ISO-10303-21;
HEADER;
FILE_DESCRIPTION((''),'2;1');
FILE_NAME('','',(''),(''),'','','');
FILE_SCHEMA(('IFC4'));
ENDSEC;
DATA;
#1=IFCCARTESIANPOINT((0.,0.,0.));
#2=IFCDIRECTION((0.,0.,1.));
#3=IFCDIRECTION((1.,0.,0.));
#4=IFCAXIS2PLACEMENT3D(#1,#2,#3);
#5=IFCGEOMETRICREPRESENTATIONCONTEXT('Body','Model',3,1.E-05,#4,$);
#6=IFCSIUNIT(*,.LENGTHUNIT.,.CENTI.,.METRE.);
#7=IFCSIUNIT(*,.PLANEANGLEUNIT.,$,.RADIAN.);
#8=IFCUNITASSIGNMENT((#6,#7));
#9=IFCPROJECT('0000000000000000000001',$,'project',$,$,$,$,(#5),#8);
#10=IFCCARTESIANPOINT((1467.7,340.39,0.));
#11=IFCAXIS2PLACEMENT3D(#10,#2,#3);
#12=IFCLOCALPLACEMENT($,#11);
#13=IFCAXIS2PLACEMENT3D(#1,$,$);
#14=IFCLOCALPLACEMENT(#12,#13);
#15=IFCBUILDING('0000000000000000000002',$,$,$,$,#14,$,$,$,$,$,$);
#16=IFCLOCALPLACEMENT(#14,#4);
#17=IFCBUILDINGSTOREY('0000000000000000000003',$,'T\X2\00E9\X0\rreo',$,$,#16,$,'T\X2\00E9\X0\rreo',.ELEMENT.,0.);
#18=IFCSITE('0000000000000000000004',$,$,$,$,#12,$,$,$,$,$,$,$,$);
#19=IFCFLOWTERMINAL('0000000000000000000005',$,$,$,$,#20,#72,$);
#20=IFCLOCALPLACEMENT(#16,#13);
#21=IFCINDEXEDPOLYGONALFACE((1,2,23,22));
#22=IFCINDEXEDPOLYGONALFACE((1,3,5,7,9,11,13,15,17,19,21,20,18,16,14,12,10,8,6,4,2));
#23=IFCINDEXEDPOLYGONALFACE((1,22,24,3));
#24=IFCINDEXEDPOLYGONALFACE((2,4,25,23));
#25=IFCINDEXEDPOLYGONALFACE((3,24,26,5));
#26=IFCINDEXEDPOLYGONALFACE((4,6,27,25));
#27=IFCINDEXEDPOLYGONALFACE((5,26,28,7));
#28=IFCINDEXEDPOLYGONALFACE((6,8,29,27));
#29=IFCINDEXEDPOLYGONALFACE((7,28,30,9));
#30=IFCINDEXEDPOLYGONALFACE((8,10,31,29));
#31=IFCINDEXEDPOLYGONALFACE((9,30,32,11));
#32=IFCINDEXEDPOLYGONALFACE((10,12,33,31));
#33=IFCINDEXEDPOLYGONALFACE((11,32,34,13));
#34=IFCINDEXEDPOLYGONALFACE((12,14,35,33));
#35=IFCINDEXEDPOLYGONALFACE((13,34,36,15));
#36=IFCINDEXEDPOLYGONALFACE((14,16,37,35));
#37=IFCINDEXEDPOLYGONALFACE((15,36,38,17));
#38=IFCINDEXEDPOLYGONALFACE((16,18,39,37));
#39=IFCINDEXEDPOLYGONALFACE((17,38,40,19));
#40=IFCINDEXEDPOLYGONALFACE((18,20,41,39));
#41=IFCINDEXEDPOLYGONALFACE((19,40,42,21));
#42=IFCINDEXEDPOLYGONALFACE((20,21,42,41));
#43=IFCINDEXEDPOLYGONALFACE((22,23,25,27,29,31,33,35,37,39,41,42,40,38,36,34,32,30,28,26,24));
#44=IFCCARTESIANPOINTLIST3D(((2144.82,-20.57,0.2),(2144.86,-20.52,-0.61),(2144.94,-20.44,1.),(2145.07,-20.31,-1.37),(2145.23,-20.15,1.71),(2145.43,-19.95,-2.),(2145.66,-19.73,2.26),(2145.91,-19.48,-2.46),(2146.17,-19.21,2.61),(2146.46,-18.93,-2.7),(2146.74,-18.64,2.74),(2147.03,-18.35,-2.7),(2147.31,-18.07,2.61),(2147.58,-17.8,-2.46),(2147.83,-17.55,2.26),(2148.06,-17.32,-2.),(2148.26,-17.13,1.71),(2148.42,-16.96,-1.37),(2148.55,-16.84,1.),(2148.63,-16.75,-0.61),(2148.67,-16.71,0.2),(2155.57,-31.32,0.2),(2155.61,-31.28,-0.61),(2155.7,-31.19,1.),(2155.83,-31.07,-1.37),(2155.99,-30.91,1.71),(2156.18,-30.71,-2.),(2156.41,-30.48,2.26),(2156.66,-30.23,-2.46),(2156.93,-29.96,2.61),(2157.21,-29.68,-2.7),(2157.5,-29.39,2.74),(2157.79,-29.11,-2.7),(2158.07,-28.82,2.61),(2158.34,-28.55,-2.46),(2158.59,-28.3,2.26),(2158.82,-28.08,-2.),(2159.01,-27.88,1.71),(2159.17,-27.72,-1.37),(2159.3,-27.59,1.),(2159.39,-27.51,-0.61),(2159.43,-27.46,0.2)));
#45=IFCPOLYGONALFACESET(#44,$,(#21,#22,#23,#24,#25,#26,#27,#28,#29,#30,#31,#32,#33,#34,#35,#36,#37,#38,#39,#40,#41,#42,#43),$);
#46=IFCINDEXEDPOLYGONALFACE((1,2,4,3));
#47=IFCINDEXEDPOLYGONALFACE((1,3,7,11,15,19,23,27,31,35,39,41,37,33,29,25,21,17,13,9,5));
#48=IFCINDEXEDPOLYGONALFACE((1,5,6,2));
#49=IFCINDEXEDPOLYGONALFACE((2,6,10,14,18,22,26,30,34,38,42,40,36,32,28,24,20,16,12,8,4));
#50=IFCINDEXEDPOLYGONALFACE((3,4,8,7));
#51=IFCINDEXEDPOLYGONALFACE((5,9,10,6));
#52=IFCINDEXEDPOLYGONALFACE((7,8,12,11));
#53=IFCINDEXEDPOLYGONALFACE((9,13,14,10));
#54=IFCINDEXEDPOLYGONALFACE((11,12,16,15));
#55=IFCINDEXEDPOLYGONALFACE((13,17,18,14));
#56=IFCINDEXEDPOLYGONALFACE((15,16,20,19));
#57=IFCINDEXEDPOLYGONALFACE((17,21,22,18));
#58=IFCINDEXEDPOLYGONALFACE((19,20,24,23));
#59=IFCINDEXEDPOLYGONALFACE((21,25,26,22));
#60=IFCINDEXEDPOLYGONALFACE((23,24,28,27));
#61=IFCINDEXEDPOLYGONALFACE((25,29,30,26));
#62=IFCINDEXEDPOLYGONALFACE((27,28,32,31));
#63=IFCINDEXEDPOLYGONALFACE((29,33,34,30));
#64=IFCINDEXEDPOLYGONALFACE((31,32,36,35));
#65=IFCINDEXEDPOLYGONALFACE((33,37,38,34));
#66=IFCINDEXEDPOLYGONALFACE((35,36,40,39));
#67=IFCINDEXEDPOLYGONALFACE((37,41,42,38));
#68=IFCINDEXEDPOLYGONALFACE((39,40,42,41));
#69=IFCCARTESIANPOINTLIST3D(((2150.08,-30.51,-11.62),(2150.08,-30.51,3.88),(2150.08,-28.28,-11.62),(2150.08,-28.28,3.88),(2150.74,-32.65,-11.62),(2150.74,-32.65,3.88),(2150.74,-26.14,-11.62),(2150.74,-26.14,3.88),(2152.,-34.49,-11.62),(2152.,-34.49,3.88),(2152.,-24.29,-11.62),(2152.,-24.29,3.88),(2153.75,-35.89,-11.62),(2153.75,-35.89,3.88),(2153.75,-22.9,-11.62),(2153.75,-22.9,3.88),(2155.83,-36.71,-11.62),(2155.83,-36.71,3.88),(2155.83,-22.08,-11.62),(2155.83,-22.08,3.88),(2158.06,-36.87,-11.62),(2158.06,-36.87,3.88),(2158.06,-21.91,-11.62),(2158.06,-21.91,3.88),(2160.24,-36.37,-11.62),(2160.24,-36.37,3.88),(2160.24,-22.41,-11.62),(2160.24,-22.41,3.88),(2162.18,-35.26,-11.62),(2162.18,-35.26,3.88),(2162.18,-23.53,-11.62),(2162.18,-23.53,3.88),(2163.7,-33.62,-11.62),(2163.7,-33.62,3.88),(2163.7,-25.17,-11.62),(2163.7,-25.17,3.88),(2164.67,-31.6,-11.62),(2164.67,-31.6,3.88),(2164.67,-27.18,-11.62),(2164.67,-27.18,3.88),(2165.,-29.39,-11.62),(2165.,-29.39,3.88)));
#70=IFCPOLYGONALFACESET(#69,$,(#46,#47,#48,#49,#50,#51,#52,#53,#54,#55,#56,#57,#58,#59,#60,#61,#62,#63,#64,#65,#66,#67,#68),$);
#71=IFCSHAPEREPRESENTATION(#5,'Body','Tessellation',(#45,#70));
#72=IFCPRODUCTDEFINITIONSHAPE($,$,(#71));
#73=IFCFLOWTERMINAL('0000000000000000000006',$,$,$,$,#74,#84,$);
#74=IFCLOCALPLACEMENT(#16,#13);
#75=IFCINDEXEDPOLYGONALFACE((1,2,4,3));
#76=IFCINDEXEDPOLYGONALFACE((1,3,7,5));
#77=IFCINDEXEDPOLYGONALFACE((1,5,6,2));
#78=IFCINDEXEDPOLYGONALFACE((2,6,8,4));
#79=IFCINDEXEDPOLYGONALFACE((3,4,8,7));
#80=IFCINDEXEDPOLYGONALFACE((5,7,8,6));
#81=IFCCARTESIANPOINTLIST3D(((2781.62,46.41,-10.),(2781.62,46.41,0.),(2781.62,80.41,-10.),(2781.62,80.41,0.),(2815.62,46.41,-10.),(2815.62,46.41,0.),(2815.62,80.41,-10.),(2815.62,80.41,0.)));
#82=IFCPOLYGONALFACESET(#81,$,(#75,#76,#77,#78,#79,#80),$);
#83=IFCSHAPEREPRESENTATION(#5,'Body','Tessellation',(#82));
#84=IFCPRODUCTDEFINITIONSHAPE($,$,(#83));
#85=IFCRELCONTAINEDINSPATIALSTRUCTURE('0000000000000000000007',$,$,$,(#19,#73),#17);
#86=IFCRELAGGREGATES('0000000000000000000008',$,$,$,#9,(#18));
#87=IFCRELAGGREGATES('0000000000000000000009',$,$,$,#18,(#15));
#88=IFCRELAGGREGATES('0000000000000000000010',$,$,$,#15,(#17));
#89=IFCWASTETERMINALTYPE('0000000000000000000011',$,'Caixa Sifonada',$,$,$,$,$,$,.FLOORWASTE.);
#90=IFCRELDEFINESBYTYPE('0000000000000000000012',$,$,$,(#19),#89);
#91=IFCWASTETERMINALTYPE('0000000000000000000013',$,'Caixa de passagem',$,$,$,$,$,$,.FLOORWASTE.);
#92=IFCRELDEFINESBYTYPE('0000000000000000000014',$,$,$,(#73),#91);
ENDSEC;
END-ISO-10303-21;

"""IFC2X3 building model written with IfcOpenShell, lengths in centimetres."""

from ifc_helpers import new_model, si_unit, frame, origin, origin_with_axes, origin_2d_with_axis, place, context, project, spatial, rectangle, circle, extrude, type_object, element, save


model = new_model("IFC2X3")

# Units and contexts
model_context = context("Model", 3, precision=1e-05, world=origin_with_axes(), identifier="Body")
ifc_project = project(units=[si_unit("LENGTHUNIT", "METRE", prefix="CENTI"), si_unit("PLANEANGLEUNIT", "RADIAN")], contexts=[model_context])

# Site, building, storey
site_placement = place(None, frame((1467.7, 340.39, 0.0), z_axis=(0.0, 0.0, 1.0), x_axis=(1.0, 0.0, 0.0)))
site = spatial("IfcSite", under=ifc_project, at=site_placement)
building_placement = place(site_placement, origin())
building = spatial("IfcBuilding", under=site, at=building_placement)
storey_placement = place(building_placement, origin_with_axes())
storey = spatial("IfcBuildingStorey", under=building, at=storey_placement, Name="Térreo", LongName="Térreo", CompositionType="ELEMENT", Elevation=0.0)

# Flow terminals
waste_terminal_type_1 = type_object("IfcWasteTerminalType", Name="Caixa Sifonada", PredefinedType="FLOORWASTE")
flow_terminal_1_placement = place(storey_placement, frame((2154.91, -26.8, 3.88), z_axis=(0.0, 0.0, 1.0), x_axis=(1.0, 0.0, 0.0)))
element("IfcFlowTerminal", 1, at=flow_terminal_1_placement, inside=storey, type_object=waste_terminal_type_1, context=model_context, shape_type="SolidModel", body=[
    extrude(circle(Radius=2.73, at=origin_2d_with_axis()), frame((2.59, -2.59, -3.88), z_axis=(-0.707107, 0.707107, 0.0), x_axis=(0.0, 0.0, 1.0)), (0.0, 0.0, 1.0), 15.21),
    extrude(circle(Radius=7.5, at=origin_2d_with_axis()), frame((2.59, -2.59, -15.5), z_axis=(0.0, 0.0, 1.0), x_axis=(1.0, 0.0, 0.0)), (0.0, 0.0, 1.0), 15.5),
])
waste_terminal_type_2 = type_object("IfcWasteTerminalType", Name="Caixa de passagem", PredefinedType="FLOORWASTE")
flow_terminal_2_placement = place(storey_placement, frame((2798.62, 63.41, 0.0), z_axis=(0.0, 0.0, 1.0), x_axis=(1.0, 0.0, 0.0)))
element("IfcFlowTerminal", 2, at=flow_terminal_2_placement, inside=storey, type_object=waste_terminal_type_2, context=model_context, shape_type="SolidModel", body=[
    extrude(rectangle(XDim=34.0, YDim=34.0, at=origin_2d_with_axis()), frame((0.0, 0.0, -10.0), z_axis=(0.0, 0.0, 1.0), x_axis=(0.0, -1.0, 0.0)), (0.0, 0.0, 1.0), 10.0),
])

save(model, "model.ifc")
